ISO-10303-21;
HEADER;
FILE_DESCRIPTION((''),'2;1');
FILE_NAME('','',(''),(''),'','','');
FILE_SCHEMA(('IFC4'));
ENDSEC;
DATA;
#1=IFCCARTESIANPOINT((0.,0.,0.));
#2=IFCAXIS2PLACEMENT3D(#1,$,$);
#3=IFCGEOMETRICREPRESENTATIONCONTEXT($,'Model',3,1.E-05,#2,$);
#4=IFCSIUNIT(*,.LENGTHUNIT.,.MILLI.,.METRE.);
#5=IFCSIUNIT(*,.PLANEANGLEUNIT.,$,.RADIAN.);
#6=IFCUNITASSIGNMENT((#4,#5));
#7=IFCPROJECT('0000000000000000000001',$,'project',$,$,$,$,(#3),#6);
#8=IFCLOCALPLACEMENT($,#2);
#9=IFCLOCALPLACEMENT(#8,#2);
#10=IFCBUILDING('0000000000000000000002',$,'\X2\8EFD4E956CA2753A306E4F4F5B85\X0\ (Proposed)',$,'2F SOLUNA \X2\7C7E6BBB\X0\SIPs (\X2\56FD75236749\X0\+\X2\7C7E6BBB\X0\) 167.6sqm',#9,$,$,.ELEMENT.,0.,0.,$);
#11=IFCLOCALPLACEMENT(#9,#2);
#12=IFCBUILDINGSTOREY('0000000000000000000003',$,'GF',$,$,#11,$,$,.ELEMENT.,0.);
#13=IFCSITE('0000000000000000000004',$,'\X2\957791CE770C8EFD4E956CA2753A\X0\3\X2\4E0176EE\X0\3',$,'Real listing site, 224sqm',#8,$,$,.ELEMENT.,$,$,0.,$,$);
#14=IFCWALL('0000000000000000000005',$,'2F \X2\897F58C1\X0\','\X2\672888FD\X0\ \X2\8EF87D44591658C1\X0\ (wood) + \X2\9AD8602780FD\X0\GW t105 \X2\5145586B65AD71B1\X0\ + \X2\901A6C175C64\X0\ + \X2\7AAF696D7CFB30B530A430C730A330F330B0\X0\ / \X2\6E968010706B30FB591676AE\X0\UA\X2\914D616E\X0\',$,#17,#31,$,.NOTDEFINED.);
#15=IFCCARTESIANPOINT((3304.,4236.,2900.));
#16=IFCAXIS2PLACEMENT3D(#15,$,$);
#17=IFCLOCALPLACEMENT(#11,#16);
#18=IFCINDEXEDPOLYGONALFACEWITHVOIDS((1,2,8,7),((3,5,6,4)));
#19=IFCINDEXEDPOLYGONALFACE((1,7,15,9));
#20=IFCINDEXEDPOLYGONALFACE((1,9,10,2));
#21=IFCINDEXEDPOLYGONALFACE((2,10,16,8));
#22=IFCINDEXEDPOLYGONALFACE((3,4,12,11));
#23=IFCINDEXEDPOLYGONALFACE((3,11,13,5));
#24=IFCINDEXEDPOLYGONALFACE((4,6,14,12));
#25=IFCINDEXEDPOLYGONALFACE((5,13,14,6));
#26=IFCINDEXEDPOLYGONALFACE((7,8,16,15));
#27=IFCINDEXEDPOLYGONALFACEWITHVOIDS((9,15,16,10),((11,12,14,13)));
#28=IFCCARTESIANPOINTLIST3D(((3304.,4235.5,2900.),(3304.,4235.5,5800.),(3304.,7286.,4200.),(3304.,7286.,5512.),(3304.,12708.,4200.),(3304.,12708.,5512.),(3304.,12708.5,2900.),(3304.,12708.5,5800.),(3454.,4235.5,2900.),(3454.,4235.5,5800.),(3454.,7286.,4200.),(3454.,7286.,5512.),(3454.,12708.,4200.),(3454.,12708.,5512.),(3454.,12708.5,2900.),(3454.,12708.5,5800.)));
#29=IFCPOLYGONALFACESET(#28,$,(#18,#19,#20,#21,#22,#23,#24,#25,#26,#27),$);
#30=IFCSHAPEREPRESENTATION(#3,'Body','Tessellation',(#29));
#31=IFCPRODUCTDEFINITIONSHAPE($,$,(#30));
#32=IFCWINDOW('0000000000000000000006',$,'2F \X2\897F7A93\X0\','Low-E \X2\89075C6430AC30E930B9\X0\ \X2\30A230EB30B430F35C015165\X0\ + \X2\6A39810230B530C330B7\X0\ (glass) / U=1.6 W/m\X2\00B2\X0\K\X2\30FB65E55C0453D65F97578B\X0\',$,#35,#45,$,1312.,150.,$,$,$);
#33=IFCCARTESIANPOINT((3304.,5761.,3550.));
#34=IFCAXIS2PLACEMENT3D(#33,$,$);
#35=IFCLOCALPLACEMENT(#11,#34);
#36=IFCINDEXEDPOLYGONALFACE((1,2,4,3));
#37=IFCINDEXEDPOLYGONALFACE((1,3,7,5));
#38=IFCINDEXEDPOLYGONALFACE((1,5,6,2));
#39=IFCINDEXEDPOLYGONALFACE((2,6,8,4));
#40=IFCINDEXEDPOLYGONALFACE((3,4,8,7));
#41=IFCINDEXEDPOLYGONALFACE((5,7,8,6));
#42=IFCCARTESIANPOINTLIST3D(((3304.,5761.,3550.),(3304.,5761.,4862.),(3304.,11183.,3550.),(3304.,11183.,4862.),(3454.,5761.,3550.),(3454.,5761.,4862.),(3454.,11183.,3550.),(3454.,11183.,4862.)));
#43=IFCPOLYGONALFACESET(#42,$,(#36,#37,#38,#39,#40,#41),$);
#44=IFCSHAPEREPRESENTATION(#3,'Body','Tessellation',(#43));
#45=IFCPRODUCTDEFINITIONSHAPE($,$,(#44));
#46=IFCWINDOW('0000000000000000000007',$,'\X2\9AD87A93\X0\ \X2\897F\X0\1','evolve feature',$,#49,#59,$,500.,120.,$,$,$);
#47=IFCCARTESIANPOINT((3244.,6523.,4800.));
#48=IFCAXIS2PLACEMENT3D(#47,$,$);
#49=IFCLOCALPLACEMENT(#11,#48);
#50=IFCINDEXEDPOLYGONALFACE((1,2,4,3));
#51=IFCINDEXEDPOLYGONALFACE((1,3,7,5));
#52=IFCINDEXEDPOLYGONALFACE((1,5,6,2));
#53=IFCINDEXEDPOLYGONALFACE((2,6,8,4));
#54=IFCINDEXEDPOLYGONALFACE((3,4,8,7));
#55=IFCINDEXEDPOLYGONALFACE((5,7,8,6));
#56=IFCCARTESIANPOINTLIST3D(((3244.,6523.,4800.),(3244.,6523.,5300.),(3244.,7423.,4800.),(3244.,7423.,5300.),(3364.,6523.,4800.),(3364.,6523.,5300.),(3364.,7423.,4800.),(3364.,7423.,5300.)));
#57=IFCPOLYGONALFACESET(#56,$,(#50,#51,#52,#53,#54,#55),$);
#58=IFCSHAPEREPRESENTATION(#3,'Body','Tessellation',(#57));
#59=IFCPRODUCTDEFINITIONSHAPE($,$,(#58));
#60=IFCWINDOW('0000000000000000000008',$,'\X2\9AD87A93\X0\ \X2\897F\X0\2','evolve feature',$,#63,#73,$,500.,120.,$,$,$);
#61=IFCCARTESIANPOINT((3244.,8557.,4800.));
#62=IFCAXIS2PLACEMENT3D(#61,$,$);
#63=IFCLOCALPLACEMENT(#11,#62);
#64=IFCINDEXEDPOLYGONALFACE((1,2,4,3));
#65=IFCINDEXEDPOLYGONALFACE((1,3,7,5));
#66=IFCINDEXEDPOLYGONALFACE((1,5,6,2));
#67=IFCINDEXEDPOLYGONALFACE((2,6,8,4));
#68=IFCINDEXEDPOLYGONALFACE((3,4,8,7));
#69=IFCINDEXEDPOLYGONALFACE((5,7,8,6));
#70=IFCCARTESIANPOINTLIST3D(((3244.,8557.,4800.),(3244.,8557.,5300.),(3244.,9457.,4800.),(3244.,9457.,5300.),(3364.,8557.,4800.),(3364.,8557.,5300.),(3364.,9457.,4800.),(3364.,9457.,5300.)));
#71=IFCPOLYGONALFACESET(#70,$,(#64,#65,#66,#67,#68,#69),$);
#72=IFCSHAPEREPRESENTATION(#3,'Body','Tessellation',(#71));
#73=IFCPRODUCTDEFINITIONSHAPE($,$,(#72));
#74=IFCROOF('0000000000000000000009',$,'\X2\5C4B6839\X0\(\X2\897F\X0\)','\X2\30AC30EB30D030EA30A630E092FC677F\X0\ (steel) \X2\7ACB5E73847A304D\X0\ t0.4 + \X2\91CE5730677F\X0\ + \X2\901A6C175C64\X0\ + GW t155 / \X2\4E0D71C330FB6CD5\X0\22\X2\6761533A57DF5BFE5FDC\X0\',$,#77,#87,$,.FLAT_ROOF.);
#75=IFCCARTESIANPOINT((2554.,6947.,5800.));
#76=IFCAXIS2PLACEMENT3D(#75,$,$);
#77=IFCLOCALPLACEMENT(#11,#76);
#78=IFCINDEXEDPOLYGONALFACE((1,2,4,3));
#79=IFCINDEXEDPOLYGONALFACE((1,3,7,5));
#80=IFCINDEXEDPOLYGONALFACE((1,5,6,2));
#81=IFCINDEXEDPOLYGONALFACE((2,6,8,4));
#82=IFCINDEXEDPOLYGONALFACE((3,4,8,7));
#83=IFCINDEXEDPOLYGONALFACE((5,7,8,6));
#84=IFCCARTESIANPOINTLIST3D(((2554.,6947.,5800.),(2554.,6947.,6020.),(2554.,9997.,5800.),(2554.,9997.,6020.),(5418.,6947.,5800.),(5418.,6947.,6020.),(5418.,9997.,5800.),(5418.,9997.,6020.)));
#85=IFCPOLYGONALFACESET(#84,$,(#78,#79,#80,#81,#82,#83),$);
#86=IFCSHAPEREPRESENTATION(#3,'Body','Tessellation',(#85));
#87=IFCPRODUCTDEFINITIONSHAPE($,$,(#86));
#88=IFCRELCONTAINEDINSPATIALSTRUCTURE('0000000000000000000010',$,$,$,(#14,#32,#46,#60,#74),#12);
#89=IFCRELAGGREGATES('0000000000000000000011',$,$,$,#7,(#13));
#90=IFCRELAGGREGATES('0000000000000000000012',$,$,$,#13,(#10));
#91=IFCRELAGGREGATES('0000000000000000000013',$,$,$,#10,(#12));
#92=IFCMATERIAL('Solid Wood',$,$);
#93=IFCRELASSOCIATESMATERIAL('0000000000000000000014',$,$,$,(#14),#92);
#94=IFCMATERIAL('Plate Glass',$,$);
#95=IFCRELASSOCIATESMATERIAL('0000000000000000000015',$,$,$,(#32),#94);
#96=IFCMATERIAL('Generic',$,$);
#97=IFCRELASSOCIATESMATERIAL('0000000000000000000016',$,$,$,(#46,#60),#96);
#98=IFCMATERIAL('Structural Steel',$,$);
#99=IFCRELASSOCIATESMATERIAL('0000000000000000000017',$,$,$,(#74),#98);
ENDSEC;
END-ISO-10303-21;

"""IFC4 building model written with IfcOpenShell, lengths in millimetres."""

from ifc_helpers import new_model, si_unit, frame, frame_2d, origin, place, context, project, spatial, rectangle, extrude, material, element, fill, save


model = new_model("IFC4")

# Units and contexts
model_context = context("Model", 3, precision=1e-05, world=origin())
ifc_project = project(units=[si_unit("LENGTHUNIT", "METRE", prefix="MILLI"), si_unit("PLANEANGLEUNIT", "RADIAN")], contexts=[model_context])

# Site, building, storey
site_placement = place(None, origin())
site = spatial("IfcSite", under=ifc_project, at=site_placement, Name="長野県軽井沢町3丁目3", ObjectType="Real listing site, 224sqm", CompositionType="ELEMENT", RefElevation=0.0)
building_placement = place(site_placement, origin())
building = spatial("IfcBuilding", under=site, at=building_placement, Name="軽井沢町の住宅 (Proposed)", ObjectType="2F SOLUNA 籾殻SIPs (国産杉+籾殻) 167.6sqm", CompositionType="ELEMENT", ElevationOfRefHeight=0.0, ElevationOfTerrain=0.0)
storey_placement = place(building_placement, origin())
storey = spatial("IfcBuildingStorey", under=building, at=storey_placement, Name="GF", CompositionType="ELEMENT", Elevation=0.0)

# Shared definitions
ifc_material_1 = material(Name="Solid Wood")
ifc_material_2 = material(Name="Generic")

# Shared definitions
ifc_material_3 = material(Name="Plate Glass")

# Wall, openings, windows
wall_1_placement = place(storey_placement, frame((3304.0, 4236.0, 2900.0)))
wall_1 = element("IfcWall", 1, at=wall_1_placement, inside=storey, material=ifc_material_1, Name="2F 西壁", Description="木製 軸組外壁 (wood) + 高性能GW t105 充填断熱 + 通気層 + 窯業系サイディング / 準耐火・外皮UA配慮", PredefinedType="NOTDEFINED", context=model_context, shape_type="SweptSolid", body=[
    extrude(rectangle(XDim=150.0, YDim=8473.0, at=frame_2d((75.0, 4236.0))), frame((3304.0, 4236.0, 2900.0)), (0.0, 0.0, 1.0), 2900.0),
])
opening_1_placement = place(storey_placement, frame((3304.0, 5761.0, 3550.0)))
opening_1 = element("IfcOpeningElement", 2, at=opening_1_placement, cuts=wall_1, PredefinedType="NOTDEFINED", context=model_context, shape_type="SweptSolid", body=[
    extrude(rectangle(XDim=150.0, YDim=5422.0, at=frame_2d((75.0, 2711.0))), frame((3304.0, 5761.0, 3550.0)), (0.0, 0.0, 1.0), 1312.0),
])
opening_2_placement = place(storey_placement, frame((3244.0, 6523.0, 4800.0)))
opening_2 = element("IfcOpeningElement", 3, at=opening_2_placement, cuts=wall_1, PredefinedType="NOTDEFINED", context=model_context, shape_type="SweptSolid", body=[
    extrude(rectangle(XDim=120.0, YDim=900.0, at=frame_2d((60.0, 450.0))), frame((3244.0, 6523.0, 4800.0)), (0.0, 0.0, 1.0), 500.0),
])
opening_3_placement = place(storey_placement, frame((3244.0, 8557.0, 4800.0)))
opening_3 = element("IfcOpeningElement", 4, at=opening_3_placement, cuts=wall_1, PredefinedType="NOTDEFINED", context=model_context, shape_type="SweptSolid", body=[
    extrude(rectangle(XDim=120.0, YDim=900.0, at=frame_2d((60.0, 450.0))), frame((3244.0, 8557.0, 4800.0)), (0.0, 0.0, 1.0), 500.0),
])
window_1_placement = place(storey_placement, frame((3304.0, 5761.0, 3550.0)))
window_1 = element("IfcWindow", 5, at=window_1_placement, inside=storey, material=ifc_material_3, Name="2F 西窓", Description="Low-E 複層ガラス アルゴン封入 + 樹脂サッシ (glass) / U=1.6 W/m²K・日射取得型", OverallHeight=1312.0, OverallWidth=150.0, context=model_context, shape_type="SweptSolid", body=[
    extrude(rectangle(XDim=150.0, YDim=5422.0, at=frame_2d((75.0, 2711.0))), frame((3304.0, 5761.0, 3550.0)), (0.0, 0.0, 1.0), 1312.0),
])
fill(opening_1, window_1)
window_2_placement = place(storey_placement, frame((3244.0, 6523.0, 4800.0)))
window_2 = element("IfcWindow", 6, at=window_2_placement, inside=storey, material=ifc_material_2, Name="高窓 西1", Description="evolve feature", OverallHeight=500.0, OverallWidth=120.0, context=model_context, shape_type="SweptSolid", body=[
    extrude(rectangle(XDim=120.0, YDim=900.0, at=frame_2d((60.0, 450.0))), frame((3244.0, 6523.0, 4800.0)), (0.0, 0.0, 1.0), 500.0),
])
fill(opening_2, window_2)
window_3_placement = place(storey_placement, frame((3244.0, 8557.0, 4800.0)))
window_3 = element("IfcWindow", 7, at=window_3_placement, inside=storey, material=ifc_material_2, Name="高窓 西2", Description="evolve feature", OverallHeight=500.0, OverallWidth=120.0, context=model_context, shape_type="SweptSolid", body=[
    extrude(rectangle(XDim=120.0, YDim=900.0, at=frame_2d((60.0, 450.0))), frame((3244.0, 8557.0, 4800.0)), (0.0, 0.0, 1.0), 500.0),
])
fill(opening_3, window_3)

# Roof
ifc_material_4 = material(Name="Structural Steel")
roof_1_placement = place(storey_placement, frame((2554.0, 6947.0, 5800.0)))
element("IfcRoof", 8, at=roof_1_placement, inside=storey, material=ifc_material_4, Name="屋根(西)", Description="ガルバリウム鋼板 (steel) 立平葺き t0.4 + 野地板 + 通気層 + GW t155 / 不燃・法22条区域対応", PredefinedType="FLAT_ROOF", context=model_context, shape_type="SweptSolid", body=[
    extrude(rectangle(XDim=2864.0, YDim=3050.0, at=frame_2d((1432.0, 1525.0))), frame((2554.0, 6947.0, 5800.0)), (0.0, 0.0, 1.0), 220.0),
])

save(model, "model.ifc")
